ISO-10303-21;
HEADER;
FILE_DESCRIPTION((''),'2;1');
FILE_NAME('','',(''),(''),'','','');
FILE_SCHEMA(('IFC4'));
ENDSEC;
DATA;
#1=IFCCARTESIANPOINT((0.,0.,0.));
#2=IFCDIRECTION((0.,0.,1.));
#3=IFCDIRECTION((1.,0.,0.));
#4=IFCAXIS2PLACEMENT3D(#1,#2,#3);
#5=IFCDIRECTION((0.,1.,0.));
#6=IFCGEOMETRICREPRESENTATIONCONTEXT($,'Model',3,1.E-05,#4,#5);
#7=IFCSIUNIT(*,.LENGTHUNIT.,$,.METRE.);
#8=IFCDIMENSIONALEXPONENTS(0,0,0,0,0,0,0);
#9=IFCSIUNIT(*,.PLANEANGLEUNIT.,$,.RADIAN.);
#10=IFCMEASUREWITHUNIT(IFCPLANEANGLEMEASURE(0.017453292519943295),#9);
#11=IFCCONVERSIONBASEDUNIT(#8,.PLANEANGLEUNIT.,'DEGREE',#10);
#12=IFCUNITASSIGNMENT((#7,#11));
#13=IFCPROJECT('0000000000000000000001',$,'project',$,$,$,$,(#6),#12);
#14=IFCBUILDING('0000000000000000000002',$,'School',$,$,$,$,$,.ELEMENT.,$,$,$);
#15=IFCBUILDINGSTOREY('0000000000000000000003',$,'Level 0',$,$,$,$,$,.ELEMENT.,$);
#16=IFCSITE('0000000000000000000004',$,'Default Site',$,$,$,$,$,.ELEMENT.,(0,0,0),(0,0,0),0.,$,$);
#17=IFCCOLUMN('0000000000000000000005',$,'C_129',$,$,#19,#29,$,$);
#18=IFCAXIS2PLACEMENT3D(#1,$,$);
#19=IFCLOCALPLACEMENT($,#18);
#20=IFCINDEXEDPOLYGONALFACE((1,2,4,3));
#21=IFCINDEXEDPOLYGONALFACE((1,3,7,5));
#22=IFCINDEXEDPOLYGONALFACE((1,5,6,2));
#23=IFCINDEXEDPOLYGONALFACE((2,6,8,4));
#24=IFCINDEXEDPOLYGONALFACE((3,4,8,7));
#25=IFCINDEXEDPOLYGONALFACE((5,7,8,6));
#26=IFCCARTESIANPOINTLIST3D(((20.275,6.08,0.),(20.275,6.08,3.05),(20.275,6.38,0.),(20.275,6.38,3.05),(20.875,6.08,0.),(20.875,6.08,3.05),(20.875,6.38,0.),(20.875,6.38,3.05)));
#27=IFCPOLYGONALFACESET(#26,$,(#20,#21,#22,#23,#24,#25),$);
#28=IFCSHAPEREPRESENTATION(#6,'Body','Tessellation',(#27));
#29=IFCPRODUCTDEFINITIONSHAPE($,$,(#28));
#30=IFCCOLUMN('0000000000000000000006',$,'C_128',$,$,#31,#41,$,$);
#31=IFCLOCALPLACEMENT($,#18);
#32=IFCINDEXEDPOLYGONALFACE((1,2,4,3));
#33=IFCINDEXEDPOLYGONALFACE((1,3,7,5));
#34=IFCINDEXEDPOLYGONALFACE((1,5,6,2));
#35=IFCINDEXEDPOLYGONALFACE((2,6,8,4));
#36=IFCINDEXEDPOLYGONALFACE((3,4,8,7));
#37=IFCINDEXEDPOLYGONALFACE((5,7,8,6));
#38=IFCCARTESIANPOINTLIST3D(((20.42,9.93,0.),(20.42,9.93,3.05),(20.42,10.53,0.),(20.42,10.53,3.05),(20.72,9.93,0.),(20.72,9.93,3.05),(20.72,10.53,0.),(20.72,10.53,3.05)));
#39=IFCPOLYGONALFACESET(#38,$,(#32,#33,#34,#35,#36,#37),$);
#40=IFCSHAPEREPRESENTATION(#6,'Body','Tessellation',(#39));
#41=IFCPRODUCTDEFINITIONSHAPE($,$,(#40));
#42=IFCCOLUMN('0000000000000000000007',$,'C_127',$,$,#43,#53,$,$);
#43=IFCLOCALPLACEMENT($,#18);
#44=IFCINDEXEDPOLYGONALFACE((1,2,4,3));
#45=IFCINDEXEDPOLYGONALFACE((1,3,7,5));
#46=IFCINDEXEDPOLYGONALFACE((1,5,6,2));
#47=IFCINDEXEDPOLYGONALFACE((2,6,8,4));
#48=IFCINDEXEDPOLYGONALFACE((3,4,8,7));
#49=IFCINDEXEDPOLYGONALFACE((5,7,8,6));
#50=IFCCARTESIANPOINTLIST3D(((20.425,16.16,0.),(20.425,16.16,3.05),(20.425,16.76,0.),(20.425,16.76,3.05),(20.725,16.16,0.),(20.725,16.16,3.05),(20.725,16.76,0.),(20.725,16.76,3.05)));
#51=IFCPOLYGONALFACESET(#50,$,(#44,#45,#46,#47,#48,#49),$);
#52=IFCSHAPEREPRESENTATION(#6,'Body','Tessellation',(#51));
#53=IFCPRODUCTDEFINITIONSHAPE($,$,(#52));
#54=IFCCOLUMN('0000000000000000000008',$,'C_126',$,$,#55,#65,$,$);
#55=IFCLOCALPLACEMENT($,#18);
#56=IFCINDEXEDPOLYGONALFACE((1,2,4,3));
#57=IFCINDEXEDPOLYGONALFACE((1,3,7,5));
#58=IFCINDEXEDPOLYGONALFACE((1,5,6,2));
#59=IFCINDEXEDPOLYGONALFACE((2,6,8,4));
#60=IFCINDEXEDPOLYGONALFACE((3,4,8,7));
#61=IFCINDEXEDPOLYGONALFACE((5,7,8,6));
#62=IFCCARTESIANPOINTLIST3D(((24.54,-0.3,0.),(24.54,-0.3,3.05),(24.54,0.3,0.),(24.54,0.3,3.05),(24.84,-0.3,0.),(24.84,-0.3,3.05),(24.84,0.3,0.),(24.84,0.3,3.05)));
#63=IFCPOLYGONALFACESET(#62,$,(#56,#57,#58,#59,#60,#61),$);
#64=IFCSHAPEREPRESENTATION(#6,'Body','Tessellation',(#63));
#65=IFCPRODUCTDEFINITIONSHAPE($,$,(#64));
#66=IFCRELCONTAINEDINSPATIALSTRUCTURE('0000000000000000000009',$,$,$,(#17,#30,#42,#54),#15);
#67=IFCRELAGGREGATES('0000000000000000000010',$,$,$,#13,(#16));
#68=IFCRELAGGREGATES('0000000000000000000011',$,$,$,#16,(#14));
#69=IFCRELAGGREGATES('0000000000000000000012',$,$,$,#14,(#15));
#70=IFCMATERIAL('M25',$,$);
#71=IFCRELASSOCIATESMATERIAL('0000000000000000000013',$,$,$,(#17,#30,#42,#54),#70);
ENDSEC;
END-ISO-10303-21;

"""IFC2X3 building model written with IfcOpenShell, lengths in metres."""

from ifc_helpers import new_model, entity, si_unit, converted_unit, direction, frame, frame_2d, origin_with_axes, place, context, project, spatial, rectangle, extrude, material, element, save


model = new_model("IFC2X3")

# Units and contexts
model_context = context("Model", 3, precision=1e-05, world=origin_with_axes(), true_north=direction((0.0, 1.0, 0.0)))
ifc_project = project(units=[si_unit("LENGTHUNIT", "METRE"), converted_unit("PLANEANGLEUNIT", "DEGREE", entity("IfcPlaneAngleMeasure", 0.017453292519943295), si_unit("PLANEANGLEUNIT", "RADIAN"), dimensions=[0, 0, 0, 0, 0, 0, 0])], contexts=[model_context])

# Site, building, storey
site = spatial("IfcSite", under=ifc_project, Name="Default Site", CompositionType="ELEMENT", RefLatitude=(0, 0, 0), RefLongitude=(0, 0, 0), RefElevation=0.0)
building = spatial("IfcBuilding", under=site, Name="School", CompositionType="ELEMENT")
storey = spatial("IfcBuildingStorey", under=building, Name="Level 0", CompositionType="ELEMENT")

# Columns
ifc_material = material(Name="M25")
placement = place(None, origin_with_axes())
element("IfcColumn", 1, at=placement, inside=storey, material=ifc_material, Name="C_129", context=model_context, shape_type="SweptSolid", body=[
    extrude(rectangle(XDim=0.6, YDim=0.3, at=frame_2d((0.0, 0.0), x_axis=(1.0, 0.0, 0.0))), frame((20.575, 6.23, 0.0), z_axis=(0.0, 0.0, 1.0), x_axis=(1.0, 0.0, 0.0)), (0.0, 0.0, 1.0), 3.05),
])
element("IfcColumn", 2, at=placement, inside=storey, material=ifc_material, Name="C_128", context=model_context, shape_type="SweptSolid", body=[
    extrude(rectangle(XDim=0.3, YDim=0.6, at=frame_2d((0.0, 0.0), x_axis=(1.0, 0.0, 0.0))), frame((20.57, 10.23, 0.0), z_axis=(0.0, 0.0, 1.0), x_axis=(1.0, 0.0, 0.0)), (0.0, 0.0, 1.0), 3.05),
])
element("IfcColumn", 3, at=placement, inside=storey, material=ifc_material, Name="C_127", context=model_context, shape_type="SweptSolid", body=[
    extrude(rectangle(XDim=0.3, YDim=0.6, at=frame_2d((0.0, 0.0), x_axis=(1.0, 0.0, 0.0))), frame((20.575, 16.46, 0.0), z_axis=(0.0, 0.0, 1.0), x_axis=(1.0, 0.0, 0.0)), (0.0, 0.0, 1.0), 3.05),
])
element("IfcColumn", 4, at=placement, inside=storey, material=ifc_material, Name="C_126", context=model_context, shape_type="SweptSolid", body=[
    extrude(rectangle(XDim=0.3, YDim=0.6, at=frame_2d((0.0, 0.0), x_axis=(1.0, 0.0, 0.0))), frame((24.69, 0.0, 0.0), z_axis=(0.0, 0.0, 1.0), x_axis=(1.0, 0.0, 0.0)), (0.0, 0.0, 1.0), 3.05),
])

save(model, "model.ifc")
